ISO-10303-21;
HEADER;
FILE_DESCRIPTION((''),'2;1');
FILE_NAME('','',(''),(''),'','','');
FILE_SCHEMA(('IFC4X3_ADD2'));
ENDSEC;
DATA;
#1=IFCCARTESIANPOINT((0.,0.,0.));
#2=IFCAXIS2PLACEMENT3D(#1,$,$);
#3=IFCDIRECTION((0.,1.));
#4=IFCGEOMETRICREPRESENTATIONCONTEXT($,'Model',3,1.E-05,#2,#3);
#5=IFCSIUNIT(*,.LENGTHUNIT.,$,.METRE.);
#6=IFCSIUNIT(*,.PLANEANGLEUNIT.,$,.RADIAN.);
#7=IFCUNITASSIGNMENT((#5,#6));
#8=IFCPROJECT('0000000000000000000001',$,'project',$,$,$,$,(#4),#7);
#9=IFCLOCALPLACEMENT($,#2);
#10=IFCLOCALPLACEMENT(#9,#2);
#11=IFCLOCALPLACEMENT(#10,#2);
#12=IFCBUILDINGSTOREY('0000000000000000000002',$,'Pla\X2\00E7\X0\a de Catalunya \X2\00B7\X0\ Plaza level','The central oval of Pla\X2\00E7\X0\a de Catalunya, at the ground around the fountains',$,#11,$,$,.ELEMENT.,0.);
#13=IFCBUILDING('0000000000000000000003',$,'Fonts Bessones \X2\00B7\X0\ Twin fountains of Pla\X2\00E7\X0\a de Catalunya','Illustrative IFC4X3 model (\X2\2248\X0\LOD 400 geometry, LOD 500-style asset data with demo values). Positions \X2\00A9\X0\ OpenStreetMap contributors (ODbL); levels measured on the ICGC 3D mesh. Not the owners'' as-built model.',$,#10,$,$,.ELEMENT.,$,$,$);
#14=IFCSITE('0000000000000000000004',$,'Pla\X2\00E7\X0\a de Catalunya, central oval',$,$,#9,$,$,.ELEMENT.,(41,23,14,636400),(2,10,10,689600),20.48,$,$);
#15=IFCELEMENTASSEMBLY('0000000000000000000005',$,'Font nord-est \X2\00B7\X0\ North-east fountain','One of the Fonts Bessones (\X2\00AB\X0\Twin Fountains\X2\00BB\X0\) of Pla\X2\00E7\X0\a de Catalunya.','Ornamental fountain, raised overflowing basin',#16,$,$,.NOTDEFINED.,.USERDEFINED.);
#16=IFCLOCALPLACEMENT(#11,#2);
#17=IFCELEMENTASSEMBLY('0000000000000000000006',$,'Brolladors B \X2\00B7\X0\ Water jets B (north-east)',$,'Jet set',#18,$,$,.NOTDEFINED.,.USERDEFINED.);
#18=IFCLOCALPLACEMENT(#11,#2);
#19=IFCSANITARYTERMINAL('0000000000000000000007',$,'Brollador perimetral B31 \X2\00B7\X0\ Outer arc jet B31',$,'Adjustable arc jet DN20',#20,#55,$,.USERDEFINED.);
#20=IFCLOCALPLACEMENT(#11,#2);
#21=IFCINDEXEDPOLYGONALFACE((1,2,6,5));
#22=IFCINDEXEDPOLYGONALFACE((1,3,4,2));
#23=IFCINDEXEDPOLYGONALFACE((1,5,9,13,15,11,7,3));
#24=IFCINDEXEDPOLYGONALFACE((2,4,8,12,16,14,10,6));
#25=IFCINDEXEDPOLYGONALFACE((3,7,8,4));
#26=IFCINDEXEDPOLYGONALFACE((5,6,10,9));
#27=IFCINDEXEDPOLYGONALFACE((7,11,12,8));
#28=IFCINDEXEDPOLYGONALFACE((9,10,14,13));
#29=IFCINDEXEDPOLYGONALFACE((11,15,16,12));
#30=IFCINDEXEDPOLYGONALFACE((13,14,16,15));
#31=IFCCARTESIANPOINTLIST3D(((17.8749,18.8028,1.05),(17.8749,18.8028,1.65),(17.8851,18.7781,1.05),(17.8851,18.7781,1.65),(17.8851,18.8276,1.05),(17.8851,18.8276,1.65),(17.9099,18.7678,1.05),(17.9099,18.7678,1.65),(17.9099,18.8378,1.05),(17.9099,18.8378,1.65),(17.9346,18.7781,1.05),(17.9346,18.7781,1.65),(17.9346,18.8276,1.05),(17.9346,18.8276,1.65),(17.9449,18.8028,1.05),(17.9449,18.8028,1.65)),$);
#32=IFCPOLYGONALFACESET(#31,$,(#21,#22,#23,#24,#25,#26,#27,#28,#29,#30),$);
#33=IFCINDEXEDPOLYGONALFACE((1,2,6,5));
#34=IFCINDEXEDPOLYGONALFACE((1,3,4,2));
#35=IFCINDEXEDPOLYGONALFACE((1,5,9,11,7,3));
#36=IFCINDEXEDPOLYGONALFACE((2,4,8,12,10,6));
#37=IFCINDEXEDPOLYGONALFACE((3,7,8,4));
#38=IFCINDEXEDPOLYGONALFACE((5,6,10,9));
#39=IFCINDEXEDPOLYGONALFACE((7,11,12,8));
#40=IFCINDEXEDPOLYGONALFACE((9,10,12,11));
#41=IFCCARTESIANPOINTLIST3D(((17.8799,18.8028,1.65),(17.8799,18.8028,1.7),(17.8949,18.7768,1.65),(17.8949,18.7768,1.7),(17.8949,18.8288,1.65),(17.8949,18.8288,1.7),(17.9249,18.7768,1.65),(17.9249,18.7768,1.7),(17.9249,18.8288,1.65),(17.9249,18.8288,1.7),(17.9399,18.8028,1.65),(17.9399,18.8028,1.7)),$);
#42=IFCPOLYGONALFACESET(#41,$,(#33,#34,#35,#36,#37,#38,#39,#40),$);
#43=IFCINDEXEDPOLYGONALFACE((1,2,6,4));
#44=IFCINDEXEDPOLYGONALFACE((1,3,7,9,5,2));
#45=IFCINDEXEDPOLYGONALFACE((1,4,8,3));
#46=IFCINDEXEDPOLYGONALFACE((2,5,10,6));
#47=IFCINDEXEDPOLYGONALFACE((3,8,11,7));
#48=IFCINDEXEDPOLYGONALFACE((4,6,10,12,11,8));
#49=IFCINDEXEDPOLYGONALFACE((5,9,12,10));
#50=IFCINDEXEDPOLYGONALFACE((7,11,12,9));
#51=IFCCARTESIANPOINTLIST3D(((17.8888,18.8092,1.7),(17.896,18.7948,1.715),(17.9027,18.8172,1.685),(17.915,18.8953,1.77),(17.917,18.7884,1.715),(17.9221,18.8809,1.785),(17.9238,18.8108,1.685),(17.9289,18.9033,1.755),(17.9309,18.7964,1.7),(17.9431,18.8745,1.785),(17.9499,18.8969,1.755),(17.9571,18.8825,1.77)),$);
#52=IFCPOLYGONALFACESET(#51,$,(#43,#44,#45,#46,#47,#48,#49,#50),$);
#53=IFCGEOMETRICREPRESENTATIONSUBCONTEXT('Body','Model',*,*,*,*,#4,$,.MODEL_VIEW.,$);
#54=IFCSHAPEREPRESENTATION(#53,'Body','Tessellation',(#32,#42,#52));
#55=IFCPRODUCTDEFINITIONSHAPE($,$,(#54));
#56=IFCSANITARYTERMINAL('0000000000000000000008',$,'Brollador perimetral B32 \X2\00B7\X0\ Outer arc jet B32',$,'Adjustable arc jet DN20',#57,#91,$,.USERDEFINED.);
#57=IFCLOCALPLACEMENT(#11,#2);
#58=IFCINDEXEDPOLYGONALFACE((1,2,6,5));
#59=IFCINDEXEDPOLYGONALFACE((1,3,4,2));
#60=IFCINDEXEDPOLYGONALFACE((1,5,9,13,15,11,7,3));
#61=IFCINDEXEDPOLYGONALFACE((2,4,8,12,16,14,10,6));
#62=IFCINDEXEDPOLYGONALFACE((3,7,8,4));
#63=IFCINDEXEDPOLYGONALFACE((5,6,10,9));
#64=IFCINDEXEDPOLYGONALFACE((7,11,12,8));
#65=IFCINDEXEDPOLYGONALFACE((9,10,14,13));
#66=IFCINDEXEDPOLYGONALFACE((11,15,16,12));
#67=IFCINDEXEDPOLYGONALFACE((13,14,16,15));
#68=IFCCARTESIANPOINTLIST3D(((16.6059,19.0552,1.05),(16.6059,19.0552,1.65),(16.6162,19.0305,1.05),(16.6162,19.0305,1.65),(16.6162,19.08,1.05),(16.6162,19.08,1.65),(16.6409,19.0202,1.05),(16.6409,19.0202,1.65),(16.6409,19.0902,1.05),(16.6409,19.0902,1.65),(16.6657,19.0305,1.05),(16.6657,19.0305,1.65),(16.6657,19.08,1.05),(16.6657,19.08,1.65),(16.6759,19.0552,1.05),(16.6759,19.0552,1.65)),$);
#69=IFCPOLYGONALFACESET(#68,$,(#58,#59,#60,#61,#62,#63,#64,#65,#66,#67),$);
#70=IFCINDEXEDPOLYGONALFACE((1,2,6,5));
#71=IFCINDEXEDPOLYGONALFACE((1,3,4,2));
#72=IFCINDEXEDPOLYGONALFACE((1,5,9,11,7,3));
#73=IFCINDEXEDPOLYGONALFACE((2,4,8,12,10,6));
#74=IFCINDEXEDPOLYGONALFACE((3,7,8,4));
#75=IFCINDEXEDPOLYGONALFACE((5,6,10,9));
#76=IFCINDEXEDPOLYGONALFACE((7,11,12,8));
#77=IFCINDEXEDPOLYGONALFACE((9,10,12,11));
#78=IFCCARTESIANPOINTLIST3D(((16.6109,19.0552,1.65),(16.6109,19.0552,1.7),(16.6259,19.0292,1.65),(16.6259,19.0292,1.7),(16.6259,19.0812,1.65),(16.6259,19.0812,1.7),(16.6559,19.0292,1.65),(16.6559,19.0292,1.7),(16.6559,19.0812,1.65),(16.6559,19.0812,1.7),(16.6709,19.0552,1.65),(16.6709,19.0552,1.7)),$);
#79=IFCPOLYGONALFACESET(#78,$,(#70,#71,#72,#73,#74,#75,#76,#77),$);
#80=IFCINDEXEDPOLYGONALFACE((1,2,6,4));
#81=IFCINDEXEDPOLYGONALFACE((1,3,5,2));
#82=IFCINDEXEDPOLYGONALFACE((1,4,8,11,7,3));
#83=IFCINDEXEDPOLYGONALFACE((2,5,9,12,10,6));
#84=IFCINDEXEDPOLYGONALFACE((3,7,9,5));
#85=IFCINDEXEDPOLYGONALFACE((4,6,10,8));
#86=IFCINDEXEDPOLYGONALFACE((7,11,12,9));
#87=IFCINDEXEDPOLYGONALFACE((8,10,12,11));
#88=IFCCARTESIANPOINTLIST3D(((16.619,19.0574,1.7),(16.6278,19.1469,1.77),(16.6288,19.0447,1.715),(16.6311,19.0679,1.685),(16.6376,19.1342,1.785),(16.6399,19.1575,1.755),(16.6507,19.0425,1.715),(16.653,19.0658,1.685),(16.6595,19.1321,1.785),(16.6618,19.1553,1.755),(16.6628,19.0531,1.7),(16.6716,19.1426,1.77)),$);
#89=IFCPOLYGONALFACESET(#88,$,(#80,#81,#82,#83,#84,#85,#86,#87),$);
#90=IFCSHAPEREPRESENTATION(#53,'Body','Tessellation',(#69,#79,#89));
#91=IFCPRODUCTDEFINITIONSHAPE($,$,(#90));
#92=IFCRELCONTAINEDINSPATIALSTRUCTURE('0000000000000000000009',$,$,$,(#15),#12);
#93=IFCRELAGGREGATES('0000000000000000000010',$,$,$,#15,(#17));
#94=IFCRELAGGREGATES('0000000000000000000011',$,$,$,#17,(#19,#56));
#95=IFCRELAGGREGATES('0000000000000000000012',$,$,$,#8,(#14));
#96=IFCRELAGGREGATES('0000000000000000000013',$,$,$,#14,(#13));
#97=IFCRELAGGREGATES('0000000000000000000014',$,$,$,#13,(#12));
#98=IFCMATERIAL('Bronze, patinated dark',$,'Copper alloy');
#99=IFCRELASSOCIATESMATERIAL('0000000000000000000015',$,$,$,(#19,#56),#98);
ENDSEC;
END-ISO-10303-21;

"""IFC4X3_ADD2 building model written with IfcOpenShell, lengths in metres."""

from ifc_helpers import new_model, si_unit, direction, frame, origin, place, context, subcontext, project, spatial, polyline, outline, extrude, material, element, aggregate, save


model = new_model("IFC4X3_ADD2")

# Units and contexts
model_context = context("Model", 3, precision=1e-05, world=origin(), true_north=direction((0.0, 1.0)))
body_context = subcontext(model_context, "Body", "Model", "MODEL_VIEW")
ifc_project = project(units=[si_unit("LENGTHUNIT", "METRE"), si_unit("PLANEANGLEUNIT", "RADIAN")], contexts=[model_context])

# Site, building, storey
site_placement = place(None, origin())
site = spatial("IfcSite", under=ifc_project, at=site_placement, Name="Plaça de Catalunya, central oval", CompositionType="ELEMENT", RefLatitude=(41, 23, 14, 636400), RefLongitude=(2, 10, 10, 689600), RefElevation=20.48)
building_placement = place(site_placement, origin())
building = spatial("IfcBuilding", under=site, at=building_placement, Name="Fonts Bessones · Twin fountains of Plaça de Catalunya", Description="Illustrative IFC4X3 model (≈LOD 400 geometry, LOD 500-style asset data with demo values). Positions © OpenStreetMap contributors (ODbL); levels measured on the ICGC 3D mesh. Not the owners' as-built model.", CompositionType="ELEMENT")
storey_placement = place(building_placement, origin())
storey = spatial("IfcBuildingStorey", under=building, at=storey_placement, Name="Plaça de Catalunya · Plaza level", Description="The central oval of Plaça de Catalunya, at the ground around the fountains", CompositionType="ELEMENT", Elevation=0.0)

# Element assemblies, sanitary terminals
assembly_1_placement = place(building_placement, origin())
assembly_1 = element("IfcElementAssembly", 1, at=assembly_1_placement, inside=storey, Name="Font nord-est · North-east fountain", Description="One of the Fonts Bessones («Twin Fountains») of Plaça de Catalunya.", ObjectType="Ornamental fountain, raised overflowing basin", AssemblyPlace="NOTDEFINED", PredefinedType="USERDEFINED")
assembly_2_placement = place(building_placement, origin())
assembly_2 = element("IfcElementAssembly", 2, at=assembly_2_placement, Name="Brolladors B · Water jets B (north-east)", ObjectType="Jet set", AssemblyPlace="NOTDEFINED", PredefinedType="USERDEFINED")
aggregate(assembly_1, [assembly_2])
ifc_material_1 = material(Name="Bronze, patinated dark", Category="Copper alloy")
sanitary_terminal_1_placement = place(building_placement, origin())
sanitary_terminal_1 = element("IfcSanitaryTerminal", 3, at=sanitary_terminal_1_placement, material=ifc_material_1, Name="Brollador perimetral B31 · Outer arc jet B31", ObjectType="Adjustable arc jet DN20", PredefinedType="USERDEFINED", context=body_context, shape_type="SweptSolid", body=[
    extrude(outline(polyline([(17.9449, 18.8028), (17.9346, 18.8276), (17.9099, 18.8378), (17.8851, 18.8276), (17.8749, 18.8028), (17.8851, 18.7781), (17.9099, 18.7678), (17.9346, 18.7781), (17.9449, 18.8028)])), frame((0.0, 0.0, 1.05)), (0.0, 0.0, 1.0), 0.6),
    extrude(outline(polyline([(17.9399, 18.8028), (17.9249, 18.8288), (17.8949, 18.8288), (17.8799, 18.8028), (17.8949, 18.7768), (17.9249, 18.7768), (17.9399, 18.8028)])), frame((0.0, 0.0, 1.65)), (0.0, 0.0, 1.0), 0.05),
    extrude(outline(polyline([(0.022, 0.0), (0.011, 0.0191), (-0.011, 0.0191), (-0.022, 0.0), (-0.011, -0.0191), (0.011, -0.0191), (0.022, 0.0)])), frame((17.9099, 18.8028, 1.7), z_axis=(0.229137, 0.755363, 0.613941), x_axis=(0.95694, -0.290285, 0.0)), (0.0, 0.0, 1.0), 0.114),
])
sanitary_terminal_2_placement = place(building_placement, origin())
sanitary_terminal_2 = element("IfcSanitaryTerminal", 4, at=sanitary_terminal_2_placement, material=ifc_material_1, Name="Brollador perimetral B32 · Outer arc jet B32", ObjectType="Adjustable arc jet DN20", PredefinedType="USERDEFINED", context=body_context, shape_type="SweptSolid", body=[
    extrude(outline(polyline([(16.6759, 19.0552), (16.6657, 19.08), (16.6409, 19.0902), (16.6162, 19.08), (16.6059, 19.0552), (16.6162, 19.0305), (16.6409, 19.0202), (16.6657, 19.0305), (16.6759, 19.0552)])), frame((0.0, 0.0, 1.05)), (0.0, 0.0, 1.0), 0.6),
    extrude(outline(polyline([(16.6709, 19.0552), (16.6559, 19.0812), (16.6259, 19.0812), (16.6109, 19.0552), (16.6259, 19.0292), (16.6559, 19.0292), (16.6709, 19.0552)])), frame((0.0, 0.0, 1.65)), (0.0, 0.0, 1.0), 0.05),
    extrude(outline(polyline([(0.022, 0.0), (0.011, 0.0191), (-0.011, 0.0191), (-0.022, 0.0), (-0.011, -0.0191), (0.011, -0.0191), (0.022, 0.0)])), frame((16.6409, 19.0552, 1.7), z_axis=(0.07737, 0.785551, 0.613941), x_axis=(0.995185, -0.098017, 0.0)), (0.0, 0.0, 1.0), 0.114),
])
aggregate(assembly_2, [sanitary_terminal_1, sanitary_terminal_2])

save(model, "model.ifc")
